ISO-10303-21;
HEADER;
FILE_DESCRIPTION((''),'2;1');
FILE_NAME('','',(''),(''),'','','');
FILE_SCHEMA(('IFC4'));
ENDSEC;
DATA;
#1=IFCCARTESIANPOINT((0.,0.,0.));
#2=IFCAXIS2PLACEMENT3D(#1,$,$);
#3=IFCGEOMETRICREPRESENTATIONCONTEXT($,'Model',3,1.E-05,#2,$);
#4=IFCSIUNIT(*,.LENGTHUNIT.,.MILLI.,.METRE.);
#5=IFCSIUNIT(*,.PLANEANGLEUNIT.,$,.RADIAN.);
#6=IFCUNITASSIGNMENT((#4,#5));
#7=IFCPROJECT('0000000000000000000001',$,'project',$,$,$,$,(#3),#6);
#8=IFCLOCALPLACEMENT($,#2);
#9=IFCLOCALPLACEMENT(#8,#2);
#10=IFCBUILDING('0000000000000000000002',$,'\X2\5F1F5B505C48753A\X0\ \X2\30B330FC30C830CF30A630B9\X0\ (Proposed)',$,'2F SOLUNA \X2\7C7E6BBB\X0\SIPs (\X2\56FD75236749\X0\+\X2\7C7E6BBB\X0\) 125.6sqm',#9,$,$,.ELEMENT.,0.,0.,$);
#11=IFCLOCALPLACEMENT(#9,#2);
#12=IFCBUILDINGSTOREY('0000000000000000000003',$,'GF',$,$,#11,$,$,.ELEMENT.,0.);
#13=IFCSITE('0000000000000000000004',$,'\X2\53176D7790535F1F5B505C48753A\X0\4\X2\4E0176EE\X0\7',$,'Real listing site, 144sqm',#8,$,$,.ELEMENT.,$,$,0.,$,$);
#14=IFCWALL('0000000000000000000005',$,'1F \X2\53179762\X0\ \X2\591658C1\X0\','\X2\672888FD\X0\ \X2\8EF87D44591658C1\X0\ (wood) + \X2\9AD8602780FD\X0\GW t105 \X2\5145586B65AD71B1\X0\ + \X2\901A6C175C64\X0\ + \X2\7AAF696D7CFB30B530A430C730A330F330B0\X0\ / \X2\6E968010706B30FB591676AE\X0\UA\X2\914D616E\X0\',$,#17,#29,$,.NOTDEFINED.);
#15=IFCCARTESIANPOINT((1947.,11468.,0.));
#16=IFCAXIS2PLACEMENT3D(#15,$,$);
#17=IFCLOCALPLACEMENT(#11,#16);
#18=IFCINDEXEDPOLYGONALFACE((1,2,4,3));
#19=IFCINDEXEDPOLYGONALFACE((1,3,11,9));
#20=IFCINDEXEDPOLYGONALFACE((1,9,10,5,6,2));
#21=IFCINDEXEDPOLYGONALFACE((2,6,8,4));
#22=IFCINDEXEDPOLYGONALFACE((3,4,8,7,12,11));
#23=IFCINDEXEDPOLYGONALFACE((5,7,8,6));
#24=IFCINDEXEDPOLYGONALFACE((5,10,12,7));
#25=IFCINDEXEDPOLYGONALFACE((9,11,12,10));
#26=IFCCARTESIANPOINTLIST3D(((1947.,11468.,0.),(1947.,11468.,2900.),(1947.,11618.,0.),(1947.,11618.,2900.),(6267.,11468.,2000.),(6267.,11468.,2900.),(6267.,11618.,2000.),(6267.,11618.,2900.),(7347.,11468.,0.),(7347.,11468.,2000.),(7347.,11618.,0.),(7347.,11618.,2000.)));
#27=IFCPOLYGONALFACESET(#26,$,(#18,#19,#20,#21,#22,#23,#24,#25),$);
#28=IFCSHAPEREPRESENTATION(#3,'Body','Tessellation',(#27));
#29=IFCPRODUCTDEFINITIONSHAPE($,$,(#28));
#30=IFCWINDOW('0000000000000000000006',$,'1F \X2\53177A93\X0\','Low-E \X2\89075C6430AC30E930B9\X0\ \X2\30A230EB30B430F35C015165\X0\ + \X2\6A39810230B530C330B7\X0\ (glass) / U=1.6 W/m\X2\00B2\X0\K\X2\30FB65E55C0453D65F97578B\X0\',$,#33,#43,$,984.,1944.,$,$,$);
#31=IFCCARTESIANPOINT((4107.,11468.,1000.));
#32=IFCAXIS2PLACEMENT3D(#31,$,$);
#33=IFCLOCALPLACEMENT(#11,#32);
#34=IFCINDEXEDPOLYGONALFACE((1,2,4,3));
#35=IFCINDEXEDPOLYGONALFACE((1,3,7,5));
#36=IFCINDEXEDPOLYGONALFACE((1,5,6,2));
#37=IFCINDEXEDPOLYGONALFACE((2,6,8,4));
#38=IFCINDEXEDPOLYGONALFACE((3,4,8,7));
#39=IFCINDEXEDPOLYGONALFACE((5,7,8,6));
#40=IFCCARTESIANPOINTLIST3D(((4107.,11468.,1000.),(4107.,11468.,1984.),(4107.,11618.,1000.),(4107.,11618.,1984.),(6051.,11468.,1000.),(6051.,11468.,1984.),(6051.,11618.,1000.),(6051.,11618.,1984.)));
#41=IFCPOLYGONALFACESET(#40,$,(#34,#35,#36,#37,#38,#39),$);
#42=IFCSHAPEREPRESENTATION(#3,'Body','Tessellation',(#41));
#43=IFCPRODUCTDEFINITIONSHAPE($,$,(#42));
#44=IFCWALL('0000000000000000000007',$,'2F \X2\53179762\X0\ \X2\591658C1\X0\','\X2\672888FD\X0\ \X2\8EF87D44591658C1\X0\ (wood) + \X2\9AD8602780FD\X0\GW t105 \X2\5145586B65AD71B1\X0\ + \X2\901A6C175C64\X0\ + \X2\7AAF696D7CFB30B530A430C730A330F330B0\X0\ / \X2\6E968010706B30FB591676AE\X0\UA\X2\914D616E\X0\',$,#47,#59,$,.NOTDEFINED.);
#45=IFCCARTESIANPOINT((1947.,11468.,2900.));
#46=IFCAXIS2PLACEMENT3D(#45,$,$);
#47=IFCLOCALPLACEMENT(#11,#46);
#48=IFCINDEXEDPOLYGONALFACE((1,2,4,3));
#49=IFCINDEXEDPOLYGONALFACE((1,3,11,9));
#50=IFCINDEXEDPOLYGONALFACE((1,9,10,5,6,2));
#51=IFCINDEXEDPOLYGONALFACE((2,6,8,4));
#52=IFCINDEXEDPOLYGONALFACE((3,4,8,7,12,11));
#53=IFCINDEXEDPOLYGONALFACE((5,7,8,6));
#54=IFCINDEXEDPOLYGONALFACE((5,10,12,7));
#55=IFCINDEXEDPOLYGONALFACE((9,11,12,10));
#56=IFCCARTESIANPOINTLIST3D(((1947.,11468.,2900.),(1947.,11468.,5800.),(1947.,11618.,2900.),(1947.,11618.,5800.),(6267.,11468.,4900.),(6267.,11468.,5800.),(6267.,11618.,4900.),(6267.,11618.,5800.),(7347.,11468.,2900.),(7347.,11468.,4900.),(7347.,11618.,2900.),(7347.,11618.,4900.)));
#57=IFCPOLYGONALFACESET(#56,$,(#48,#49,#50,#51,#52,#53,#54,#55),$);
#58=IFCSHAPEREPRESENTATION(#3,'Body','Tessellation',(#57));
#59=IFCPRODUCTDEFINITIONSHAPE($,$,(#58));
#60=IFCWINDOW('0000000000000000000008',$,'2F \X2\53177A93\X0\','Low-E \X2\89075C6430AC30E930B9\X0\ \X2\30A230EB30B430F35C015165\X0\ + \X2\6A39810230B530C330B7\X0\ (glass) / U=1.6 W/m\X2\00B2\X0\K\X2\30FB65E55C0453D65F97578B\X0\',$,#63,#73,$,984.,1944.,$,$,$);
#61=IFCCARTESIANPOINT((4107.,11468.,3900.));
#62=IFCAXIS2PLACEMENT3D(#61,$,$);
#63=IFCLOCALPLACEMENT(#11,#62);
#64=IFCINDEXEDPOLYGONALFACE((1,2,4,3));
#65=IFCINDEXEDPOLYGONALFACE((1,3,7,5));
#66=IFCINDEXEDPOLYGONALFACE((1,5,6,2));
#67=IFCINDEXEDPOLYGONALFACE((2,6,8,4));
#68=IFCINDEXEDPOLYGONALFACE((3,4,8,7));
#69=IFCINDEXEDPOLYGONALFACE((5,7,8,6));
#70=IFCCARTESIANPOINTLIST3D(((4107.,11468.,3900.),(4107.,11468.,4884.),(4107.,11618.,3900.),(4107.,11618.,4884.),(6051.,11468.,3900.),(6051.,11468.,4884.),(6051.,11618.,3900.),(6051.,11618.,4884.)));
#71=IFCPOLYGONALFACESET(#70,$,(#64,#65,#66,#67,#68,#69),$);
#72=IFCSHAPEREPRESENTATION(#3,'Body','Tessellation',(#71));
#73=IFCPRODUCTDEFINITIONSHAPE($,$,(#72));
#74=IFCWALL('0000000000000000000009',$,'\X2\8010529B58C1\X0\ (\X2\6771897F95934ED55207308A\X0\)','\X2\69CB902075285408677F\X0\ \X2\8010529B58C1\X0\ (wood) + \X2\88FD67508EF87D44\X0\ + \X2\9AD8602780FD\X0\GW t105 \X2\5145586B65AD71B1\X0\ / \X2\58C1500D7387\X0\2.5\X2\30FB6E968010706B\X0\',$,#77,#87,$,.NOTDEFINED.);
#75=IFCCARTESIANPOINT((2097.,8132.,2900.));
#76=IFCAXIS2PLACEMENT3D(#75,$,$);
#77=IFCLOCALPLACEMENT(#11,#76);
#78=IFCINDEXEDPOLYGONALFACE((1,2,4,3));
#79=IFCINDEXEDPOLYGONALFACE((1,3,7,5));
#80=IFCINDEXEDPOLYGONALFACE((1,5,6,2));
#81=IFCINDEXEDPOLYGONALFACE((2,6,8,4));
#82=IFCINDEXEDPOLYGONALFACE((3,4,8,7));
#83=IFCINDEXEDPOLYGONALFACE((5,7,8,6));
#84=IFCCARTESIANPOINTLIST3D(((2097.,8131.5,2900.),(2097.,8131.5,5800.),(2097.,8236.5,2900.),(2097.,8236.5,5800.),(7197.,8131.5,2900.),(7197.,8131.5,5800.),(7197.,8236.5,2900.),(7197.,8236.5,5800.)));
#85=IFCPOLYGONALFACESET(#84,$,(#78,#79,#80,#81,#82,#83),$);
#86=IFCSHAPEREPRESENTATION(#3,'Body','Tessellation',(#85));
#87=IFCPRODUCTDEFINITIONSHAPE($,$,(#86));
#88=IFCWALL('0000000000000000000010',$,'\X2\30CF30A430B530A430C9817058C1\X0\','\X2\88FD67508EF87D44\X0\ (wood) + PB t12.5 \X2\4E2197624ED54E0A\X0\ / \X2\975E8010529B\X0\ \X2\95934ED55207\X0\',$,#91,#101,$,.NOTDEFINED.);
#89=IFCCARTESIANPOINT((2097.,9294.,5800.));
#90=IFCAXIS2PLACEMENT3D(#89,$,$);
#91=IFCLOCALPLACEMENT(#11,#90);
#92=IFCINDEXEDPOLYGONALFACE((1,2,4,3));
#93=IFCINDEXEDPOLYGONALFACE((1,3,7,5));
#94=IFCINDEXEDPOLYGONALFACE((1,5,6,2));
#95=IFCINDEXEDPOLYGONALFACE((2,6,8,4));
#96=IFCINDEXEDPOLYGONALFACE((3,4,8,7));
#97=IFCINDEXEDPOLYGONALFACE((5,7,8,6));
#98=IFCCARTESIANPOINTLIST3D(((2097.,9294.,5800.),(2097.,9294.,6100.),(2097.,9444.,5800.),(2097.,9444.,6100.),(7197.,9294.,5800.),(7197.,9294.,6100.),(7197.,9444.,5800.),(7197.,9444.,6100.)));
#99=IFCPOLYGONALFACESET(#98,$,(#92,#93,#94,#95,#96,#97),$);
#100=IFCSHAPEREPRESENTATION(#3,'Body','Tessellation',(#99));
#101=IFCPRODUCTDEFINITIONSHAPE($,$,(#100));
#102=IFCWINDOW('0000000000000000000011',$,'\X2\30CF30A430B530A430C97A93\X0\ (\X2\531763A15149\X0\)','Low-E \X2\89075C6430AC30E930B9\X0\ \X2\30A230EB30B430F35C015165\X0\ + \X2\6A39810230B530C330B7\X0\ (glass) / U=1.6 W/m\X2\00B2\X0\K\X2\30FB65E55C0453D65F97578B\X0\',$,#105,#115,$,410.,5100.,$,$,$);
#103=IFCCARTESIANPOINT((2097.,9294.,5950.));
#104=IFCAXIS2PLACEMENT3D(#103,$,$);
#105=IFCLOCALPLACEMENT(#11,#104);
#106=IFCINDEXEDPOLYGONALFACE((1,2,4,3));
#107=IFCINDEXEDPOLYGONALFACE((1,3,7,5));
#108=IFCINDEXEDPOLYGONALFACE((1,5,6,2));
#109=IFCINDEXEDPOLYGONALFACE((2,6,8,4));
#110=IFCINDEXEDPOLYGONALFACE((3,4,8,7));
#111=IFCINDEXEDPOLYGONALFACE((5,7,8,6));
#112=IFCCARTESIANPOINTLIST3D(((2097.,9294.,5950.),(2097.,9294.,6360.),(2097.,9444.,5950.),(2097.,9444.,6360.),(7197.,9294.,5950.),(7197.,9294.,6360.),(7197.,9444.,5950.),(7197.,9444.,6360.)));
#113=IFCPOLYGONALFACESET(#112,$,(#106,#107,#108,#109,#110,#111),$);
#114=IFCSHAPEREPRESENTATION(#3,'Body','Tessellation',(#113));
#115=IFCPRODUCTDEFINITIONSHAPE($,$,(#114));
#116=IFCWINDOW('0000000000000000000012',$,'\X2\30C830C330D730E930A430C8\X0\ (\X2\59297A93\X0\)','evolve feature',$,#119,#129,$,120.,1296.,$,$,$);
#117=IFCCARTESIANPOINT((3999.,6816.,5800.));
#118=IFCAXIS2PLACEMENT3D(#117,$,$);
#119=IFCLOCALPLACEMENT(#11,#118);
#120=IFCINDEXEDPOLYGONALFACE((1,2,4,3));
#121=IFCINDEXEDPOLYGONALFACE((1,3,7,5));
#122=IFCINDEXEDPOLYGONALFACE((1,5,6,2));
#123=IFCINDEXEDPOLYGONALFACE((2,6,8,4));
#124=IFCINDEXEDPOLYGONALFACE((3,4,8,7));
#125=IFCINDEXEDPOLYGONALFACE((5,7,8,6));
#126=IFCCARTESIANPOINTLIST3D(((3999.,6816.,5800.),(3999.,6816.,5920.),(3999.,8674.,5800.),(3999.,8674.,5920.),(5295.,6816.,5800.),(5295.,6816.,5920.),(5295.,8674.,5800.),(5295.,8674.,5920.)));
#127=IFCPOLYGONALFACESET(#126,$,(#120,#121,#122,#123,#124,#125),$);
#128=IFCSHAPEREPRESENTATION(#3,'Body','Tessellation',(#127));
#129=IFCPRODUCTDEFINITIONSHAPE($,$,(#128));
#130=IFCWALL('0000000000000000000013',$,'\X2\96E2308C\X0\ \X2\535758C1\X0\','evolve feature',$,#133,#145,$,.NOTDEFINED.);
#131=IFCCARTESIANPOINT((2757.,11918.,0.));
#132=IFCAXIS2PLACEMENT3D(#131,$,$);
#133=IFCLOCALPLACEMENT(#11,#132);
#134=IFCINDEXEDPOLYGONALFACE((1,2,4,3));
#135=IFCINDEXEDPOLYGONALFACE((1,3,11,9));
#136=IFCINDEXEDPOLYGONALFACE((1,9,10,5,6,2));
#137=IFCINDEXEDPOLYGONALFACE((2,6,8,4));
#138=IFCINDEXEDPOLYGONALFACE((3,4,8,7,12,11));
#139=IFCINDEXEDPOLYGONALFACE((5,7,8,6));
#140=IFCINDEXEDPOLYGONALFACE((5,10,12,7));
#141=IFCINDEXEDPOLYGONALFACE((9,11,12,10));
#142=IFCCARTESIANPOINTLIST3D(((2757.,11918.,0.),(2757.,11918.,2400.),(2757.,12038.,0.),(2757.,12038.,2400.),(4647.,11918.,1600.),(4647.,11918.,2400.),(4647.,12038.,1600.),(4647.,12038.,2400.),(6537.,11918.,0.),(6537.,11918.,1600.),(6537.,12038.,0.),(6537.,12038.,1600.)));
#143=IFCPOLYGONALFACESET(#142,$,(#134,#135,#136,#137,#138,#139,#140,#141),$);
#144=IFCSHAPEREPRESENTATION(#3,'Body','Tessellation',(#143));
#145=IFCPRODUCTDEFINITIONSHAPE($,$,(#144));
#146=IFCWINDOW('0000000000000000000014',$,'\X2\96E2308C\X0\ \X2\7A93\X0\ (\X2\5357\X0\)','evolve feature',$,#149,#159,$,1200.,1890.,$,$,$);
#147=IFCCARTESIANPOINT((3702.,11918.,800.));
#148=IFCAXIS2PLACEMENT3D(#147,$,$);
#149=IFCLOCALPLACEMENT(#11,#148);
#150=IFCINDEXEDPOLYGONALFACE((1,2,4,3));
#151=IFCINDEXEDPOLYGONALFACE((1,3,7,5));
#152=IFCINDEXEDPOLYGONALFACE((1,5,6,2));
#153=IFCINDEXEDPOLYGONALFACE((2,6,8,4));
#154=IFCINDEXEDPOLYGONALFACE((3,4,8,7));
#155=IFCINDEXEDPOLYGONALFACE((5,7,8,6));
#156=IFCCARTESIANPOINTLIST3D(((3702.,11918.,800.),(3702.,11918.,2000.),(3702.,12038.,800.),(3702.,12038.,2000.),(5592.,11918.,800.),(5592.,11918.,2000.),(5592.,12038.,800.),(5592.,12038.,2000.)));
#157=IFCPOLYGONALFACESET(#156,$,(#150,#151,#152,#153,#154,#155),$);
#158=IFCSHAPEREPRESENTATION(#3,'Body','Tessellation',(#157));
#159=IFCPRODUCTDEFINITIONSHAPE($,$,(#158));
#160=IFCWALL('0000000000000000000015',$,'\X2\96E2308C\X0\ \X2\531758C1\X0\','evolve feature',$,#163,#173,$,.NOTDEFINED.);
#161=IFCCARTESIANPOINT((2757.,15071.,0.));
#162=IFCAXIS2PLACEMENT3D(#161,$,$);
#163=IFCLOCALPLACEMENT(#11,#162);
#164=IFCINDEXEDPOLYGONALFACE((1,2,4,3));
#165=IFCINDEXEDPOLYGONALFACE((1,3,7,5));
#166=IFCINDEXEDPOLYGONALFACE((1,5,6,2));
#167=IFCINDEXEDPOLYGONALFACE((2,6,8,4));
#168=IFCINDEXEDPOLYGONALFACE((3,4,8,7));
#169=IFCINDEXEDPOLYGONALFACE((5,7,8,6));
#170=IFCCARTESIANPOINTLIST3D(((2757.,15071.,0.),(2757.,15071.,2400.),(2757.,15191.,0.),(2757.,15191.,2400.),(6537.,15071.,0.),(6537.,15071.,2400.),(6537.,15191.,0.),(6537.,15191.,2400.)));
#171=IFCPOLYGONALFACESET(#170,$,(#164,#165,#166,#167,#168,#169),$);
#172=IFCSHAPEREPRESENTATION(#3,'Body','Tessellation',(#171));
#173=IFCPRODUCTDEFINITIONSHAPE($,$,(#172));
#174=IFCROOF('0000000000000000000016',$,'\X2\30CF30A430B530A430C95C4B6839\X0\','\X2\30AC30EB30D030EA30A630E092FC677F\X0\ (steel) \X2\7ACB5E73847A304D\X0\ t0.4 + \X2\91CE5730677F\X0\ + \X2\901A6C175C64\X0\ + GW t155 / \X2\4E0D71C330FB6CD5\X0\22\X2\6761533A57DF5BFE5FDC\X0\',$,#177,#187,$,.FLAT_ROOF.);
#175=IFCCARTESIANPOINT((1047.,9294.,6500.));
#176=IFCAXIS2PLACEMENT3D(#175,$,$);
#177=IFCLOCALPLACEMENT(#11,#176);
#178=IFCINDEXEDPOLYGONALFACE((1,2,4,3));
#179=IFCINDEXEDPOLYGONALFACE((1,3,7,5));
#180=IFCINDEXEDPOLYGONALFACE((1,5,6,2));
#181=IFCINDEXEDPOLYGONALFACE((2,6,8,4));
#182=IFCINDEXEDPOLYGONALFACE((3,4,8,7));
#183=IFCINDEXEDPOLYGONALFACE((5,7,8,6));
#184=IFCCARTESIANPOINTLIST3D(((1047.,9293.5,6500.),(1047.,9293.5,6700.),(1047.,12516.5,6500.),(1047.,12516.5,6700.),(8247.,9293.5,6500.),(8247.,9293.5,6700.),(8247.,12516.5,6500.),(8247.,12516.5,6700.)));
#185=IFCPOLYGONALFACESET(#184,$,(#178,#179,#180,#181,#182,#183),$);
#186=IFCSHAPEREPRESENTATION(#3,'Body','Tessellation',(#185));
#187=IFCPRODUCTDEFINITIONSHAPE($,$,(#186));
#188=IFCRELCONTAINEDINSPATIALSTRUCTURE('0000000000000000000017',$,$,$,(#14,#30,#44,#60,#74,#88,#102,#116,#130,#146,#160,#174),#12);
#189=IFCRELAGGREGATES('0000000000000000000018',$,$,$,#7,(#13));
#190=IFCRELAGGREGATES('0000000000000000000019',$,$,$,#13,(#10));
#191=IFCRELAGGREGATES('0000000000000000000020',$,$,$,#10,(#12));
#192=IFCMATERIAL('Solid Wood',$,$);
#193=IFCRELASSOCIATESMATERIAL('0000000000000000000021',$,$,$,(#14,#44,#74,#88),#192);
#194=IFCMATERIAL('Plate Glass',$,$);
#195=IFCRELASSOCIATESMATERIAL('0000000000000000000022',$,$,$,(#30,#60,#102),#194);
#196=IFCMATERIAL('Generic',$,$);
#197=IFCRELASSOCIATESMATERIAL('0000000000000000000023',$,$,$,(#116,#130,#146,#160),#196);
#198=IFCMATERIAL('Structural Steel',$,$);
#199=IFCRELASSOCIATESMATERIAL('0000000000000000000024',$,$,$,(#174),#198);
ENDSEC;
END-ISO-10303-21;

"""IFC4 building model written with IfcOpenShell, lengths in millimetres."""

from ifc_helpers import new_model, si_unit, frame, frame_2d, origin, place, context, project, spatial, rectangle, extrude, material, element, fill, save


model = new_model("IFC4")

# Units and contexts
model_context = context("Model", 3, precision=1e-05, world=origin())
ifc_project = project(units=[si_unit("LENGTHUNIT", "METRE", prefix="MILLI"), si_unit("PLANEANGLEUNIT", "RADIAN")], contexts=[model_context])

# Site, building, storey
site_placement = place(None, origin())
site = spatial("IfcSite", under=ifc_project, at=site_placement, Name="北海道弟子屈町4丁目7", ObjectType="Real listing site, 144sqm", CompositionType="ELEMENT", RefElevation=0.0)
building_placement = place(site_placement, origin())
building = spatial("IfcBuilding", under=site, at=building_placement, Name="弟子屈町 コートハウス (Proposed)", ObjectType="2F SOLUNA 籾殻SIPs (国産杉+籾殻) 125.6sqm", CompositionType="ELEMENT", ElevationOfRefHeight=0.0, ElevationOfTerrain=0.0)
storey_placement = place(building_placement, origin())
storey = spatial("IfcBuildingStorey", under=building, at=storey_placement, Name="GF", CompositionType="ELEMENT", Elevation=0.0)

# Shared definitions
ifc_material_1 = material(Name="Generic")

# Wall, opening, window
ifc_material_2 = material(Name="Solid Wood")
wall_1_placement = place(storey_placement, frame((1947.0, 11468.0, 0.0)))
wall_1 = element("IfcWall", 1, at=wall_1_placement, inside=storey, material=ifc_material_2, Name="1F 北面 外壁", Description="木製 軸組外壁 (wood) + 高性能GW t105 充填断熱 + 通気層 + 窯業系サイディング / 準耐火・外皮UA配慮", PredefinedType="NOTDEFINED", context=model_context, shape_type="SweptSolid", body=[
    extrude(rectangle(XDim=5400.0, YDim=150.0, at=frame_2d((2700.0, 75.0))), frame((1947.0, 11468.0, 0.0)), (0.0, 0.0, 1.0), 2900.0),
])
opening_1_placement = place(storey_placement, frame((4107.0, 11468.0, 1000.0)))
opening_1 = element("IfcOpeningElement", 2, at=opening_1_placement, cuts=wall_1, PredefinedType="NOTDEFINED", context=model_context, shape_type="SweptSolid", body=[
    extrude(rectangle(XDim=1944.0, YDim=150.0, at=frame_2d((972.0, 75.0))), frame((4107.0, 11468.0, 1000.0)), (0.0, 0.0, 1.0), 984.0),
])
ifc_material_3 = material(Name="Plate Glass")
window_1_placement = place(storey_placement, frame((4107.0, 11468.0, 1000.0)))
window_1 = element("IfcWindow", 3, at=window_1_placement, inside=storey, material=ifc_material_3, Name="1F 北窓", Description="Low-E 複層ガラス アルゴン封入 + 樹脂サッシ (glass) / U=1.6 W/m²K・日射取得型", OverallHeight=984.0, OverallWidth=1944.0, context=model_context, shape_type="SweptSolid", body=[
    extrude(rectangle(XDim=1944.0, YDim=150.0, at=frame_2d((972.0, 75.0))), frame((4107.0, 11468.0, 1000.0)), (0.0, 0.0, 1.0), 984.0),
])
fill(opening_1, window_1)

# Wall, opening, window
wall_2_placement = place(storey_placement, frame((1947.0, 11468.0, 2900.0)))
wall_2 = element("IfcWall", 4, at=wall_2_placement, inside=storey, material=ifc_material_2, Name="2F 北面 外壁", Description="木製 軸組外壁 (wood) + 高性能GW t105 充填断熱 + 通気層 + 窯業系サイディング / 準耐火・外皮UA配慮", PredefinedType="NOTDEFINED", context=model_context, shape_type="SweptSolid", body=[
    extrude(rectangle(XDim=5400.0, YDim=150.0, at=frame_2d((2700.0, 75.0))), frame((1947.0, 11468.0, 2900.0)), (0.0, 0.0, 1.0), 2900.0),
])
opening_2_placement = place(storey_placement, frame((4107.0, 11468.0, 3900.0)))
opening_2 = element("IfcOpeningElement", 5, at=opening_2_placement, cuts=wall_2, PredefinedType="NOTDEFINED", context=model_context, shape_type="SweptSolid", body=[
    extrude(rectangle(XDim=1944.0, YDim=150.0, at=frame_2d((972.0, 75.0))), frame((4107.0, 11468.0, 3900.0)), (0.0, 0.0, 1.0), 984.0),
])
window_2_placement = place(storey_placement, frame((4107.0, 11468.0, 3900.0)))
window_2 = element("IfcWindow", 6, at=window_2_placement, inside=storey, material=ifc_material_3, Name="2F 北窓", Description="Low-E 複層ガラス アルゴン封入 + 樹脂サッシ (glass) / U=1.6 W/m²K・日射取得型", OverallHeight=984.0, OverallWidth=1944.0, context=model_context, shape_type="SweptSolid", body=[
    extrude(rectangle(XDim=1944.0, YDim=150.0, at=frame_2d((972.0, 75.0))), frame((4107.0, 11468.0, 3900.0)), (0.0, 0.0, 1.0), 984.0),
])
fill(opening_2, window_2)

# Wall
wall_3_placement = place(storey_placement, frame((2097.0, 8132.0, 2900.0)))
element("IfcWall", 7, at=wall_3_placement, inside=storey, material=ifc_material_2, Name="耐力壁 (東西間仕切り)", Description="構造用合板 耐力壁 (wood) + 製材軸組 + 高性能GW t105 充填断熱 / 壁倍率2.5・準耐火", PredefinedType="NOTDEFINED", context=model_context, shape_type="SweptSolid", body=[
    extrude(rectangle(XDim=5100.0, YDim=105.0, at=frame_2d((2550.0, 52.0))), frame((2097.0, 8132.0, 2900.0)), (0.0, 0.0, 1.0), 2900.0),
])

# Wall, opening, window
wall_4_placement = place(storey_placement, frame((2097.0, 9294.0, 5800.0)))
wall_4 = element("IfcWall", 8, at=wall_4_placement, inside=storey, material=ifc_material_2, Name="ハイサイド腰壁", Description="製材軸組 (wood) + PB t12.5 両面仕上 / 非耐力 間仕切", PredefinedType="NOTDEFINED", context=model_context, shape_type="SweptSolid", body=[
    extrude(rectangle(XDim=5100.0, YDim=150.0, at=frame_2d((2550.0, 75.0))), frame((2097.0, 9294.0, 5800.0)), (0.0, 0.0, 1.0), 700.0),
])
opening_3_placement = place(storey_placement, frame((2097.0, 9294.0, 5950.0)))
opening_3 = element("IfcOpeningElement", 9, at=opening_3_placement, cuts=wall_4, PredefinedType="NOTDEFINED", context=model_context, shape_type="SweptSolid", body=[
    extrude(rectangle(XDim=5100.0, YDim=150.0, at=frame_2d((2550.0, 75.0))), frame((2097.0, 9294.0, 5950.0)), (0.0, 0.0, 1.0), 410.0),
])
window_3_placement = place(storey_placement, frame((2097.0, 9294.0, 5950.0)))
window_3 = element("IfcWindow", 10, at=window_3_placement, inside=storey, material=ifc_material_3, Name="ハイサイド窓 (北採光)", Description="Low-E 複層ガラス アルゴン封入 + 樹脂サッシ (glass) / U=1.6 W/m²K・日射取得型", OverallHeight=410.0, OverallWidth=5100.0, context=model_context, shape_type="SweptSolid", body=[
    extrude(rectangle(XDim=5100.0, YDim=150.0, at=frame_2d((2550.0, 75.0))), frame((2097.0, 9294.0, 5950.0)), (0.0, 0.0, 1.0), 410.0),
])
fill(opening_3, window_3)

# Window
window_4_placement = place(storey_placement, frame((3999.0, 6816.0, 5800.0)))
element("IfcWindow", 11, at=window_4_placement, inside=storey, material=ifc_material_1, Name="トップライト (天窓)", Description="evolve feature", OverallHeight=120.0, OverallWidth=1296.0, context=model_context, shape_type="SweptSolid", body=[
    extrude(rectangle(XDim=1296.0, YDim=1858.0, at=frame_2d((648.0, 929.0))), frame((3999.0, 6816.0, 5800.0)), (0.0, 0.0, 1.0), 120.0),
])

# Wall, opening, window
wall_5_placement = place(storey_placement, frame((2757.0, 11918.0, 0.0)))
wall_5 = element("IfcWall", 12, at=wall_5_placement, inside=storey, material=ifc_material_1, Name="離れ 南壁", Description="evolve feature", PredefinedType="NOTDEFINED", context=model_context, shape_type="SweptSolid", body=[
    extrude(rectangle(XDim=3780.0, YDim=120.0, at=frame_2d((1890.0, 60.0))), frame((2757.0, 11918.0, 0.0)), (0.0, 0.0, 1.0), 2400.0),
])
opening_4_placement = place(storey_placement, frame((3702.0, 11918.0, 800.0)))
opening_4 = element("IfcOpeningElement", 13, at=opening_4_placement, cuts=wall_5, PredefinedType="NOTDEFINED", context=model_context, shape_type="SweptSolid", body=[
    extrude(rectangle(XDim=1890.0, YDim=120.0, at=frame_2d((945.0, 60.0))), frame((3702.0, 11918.0, 800.0)), (0.0, 0.0, 1.0), 1200.0),
])
window_5_placement = place(storey_placement, frame((3702.0, 11918.0, 800.0)))
window_5 = element("IfcWindow", 14, at=window_5_placement, inside=storey, material=ifc_material_1, Name="離れ 窓 (南)", Description="evolve feature", OverallHeight=1200.0, OverallWidth=1890.0, context=model_context, shape_type="SweptSolid", body=[
    extrude(rectangle(XDim=1890.0, YDim=120.0, at=frame_2d((945.0, 60.0))), frame((3702.0, 11918.0, 800.0)), (0.0, 0.0, 1.0), 1200.0),
])
fill(opening_4, window_5)

# Wall
wall_6_placement = place(storey_placement, frame((2757.0, 15071.0, 0.0)))
element("IfcWall", 15, at=wall_6_placement, inside=storey, material=ifc_material_1, Name="離れ 北壁", Description="evolve feature", PredefinedType="NOTDEFINED", context=model_context, shape_type="SweptSolid", body=[
    extrude(rectangle(XDim=3780.0, YDim=120.0, at=frame_2d((1890.0, 60.0))), frame((2757.0, 15071.0, 0.0)), (0.0, 0.0, 1.0), 2400.0),
])

# Roof
ifc_material_4 = material(Name="Structural Steel")
roof_1_placement = place(storey_placement, frame((1047.0, 9294.0, 6500.0)))
element("IfcRoof", 16, at=roof_1_placement, inside=storey, material=ifc_material_4, Name="ハイサイド屋根", Description="ガルバリウム鋼板 (steel) 立平葺き t0.4 + 野地板 + 通気層 + GW t155 / 不燃・法22条区域対応", PredefinedType="FLAT_ROOF", context=model_context, shape_type="SweptSolid", body=[
    extrude(rectangle(XDim=7200.0, YDim=3223.0, at=frame_2d((3600.0, 1611.0))), frame((1047.0, 9294.0, 6500.0)), (0.0, 0.0, 1.0), 200.0),
])

save(model, "model.ifc")
